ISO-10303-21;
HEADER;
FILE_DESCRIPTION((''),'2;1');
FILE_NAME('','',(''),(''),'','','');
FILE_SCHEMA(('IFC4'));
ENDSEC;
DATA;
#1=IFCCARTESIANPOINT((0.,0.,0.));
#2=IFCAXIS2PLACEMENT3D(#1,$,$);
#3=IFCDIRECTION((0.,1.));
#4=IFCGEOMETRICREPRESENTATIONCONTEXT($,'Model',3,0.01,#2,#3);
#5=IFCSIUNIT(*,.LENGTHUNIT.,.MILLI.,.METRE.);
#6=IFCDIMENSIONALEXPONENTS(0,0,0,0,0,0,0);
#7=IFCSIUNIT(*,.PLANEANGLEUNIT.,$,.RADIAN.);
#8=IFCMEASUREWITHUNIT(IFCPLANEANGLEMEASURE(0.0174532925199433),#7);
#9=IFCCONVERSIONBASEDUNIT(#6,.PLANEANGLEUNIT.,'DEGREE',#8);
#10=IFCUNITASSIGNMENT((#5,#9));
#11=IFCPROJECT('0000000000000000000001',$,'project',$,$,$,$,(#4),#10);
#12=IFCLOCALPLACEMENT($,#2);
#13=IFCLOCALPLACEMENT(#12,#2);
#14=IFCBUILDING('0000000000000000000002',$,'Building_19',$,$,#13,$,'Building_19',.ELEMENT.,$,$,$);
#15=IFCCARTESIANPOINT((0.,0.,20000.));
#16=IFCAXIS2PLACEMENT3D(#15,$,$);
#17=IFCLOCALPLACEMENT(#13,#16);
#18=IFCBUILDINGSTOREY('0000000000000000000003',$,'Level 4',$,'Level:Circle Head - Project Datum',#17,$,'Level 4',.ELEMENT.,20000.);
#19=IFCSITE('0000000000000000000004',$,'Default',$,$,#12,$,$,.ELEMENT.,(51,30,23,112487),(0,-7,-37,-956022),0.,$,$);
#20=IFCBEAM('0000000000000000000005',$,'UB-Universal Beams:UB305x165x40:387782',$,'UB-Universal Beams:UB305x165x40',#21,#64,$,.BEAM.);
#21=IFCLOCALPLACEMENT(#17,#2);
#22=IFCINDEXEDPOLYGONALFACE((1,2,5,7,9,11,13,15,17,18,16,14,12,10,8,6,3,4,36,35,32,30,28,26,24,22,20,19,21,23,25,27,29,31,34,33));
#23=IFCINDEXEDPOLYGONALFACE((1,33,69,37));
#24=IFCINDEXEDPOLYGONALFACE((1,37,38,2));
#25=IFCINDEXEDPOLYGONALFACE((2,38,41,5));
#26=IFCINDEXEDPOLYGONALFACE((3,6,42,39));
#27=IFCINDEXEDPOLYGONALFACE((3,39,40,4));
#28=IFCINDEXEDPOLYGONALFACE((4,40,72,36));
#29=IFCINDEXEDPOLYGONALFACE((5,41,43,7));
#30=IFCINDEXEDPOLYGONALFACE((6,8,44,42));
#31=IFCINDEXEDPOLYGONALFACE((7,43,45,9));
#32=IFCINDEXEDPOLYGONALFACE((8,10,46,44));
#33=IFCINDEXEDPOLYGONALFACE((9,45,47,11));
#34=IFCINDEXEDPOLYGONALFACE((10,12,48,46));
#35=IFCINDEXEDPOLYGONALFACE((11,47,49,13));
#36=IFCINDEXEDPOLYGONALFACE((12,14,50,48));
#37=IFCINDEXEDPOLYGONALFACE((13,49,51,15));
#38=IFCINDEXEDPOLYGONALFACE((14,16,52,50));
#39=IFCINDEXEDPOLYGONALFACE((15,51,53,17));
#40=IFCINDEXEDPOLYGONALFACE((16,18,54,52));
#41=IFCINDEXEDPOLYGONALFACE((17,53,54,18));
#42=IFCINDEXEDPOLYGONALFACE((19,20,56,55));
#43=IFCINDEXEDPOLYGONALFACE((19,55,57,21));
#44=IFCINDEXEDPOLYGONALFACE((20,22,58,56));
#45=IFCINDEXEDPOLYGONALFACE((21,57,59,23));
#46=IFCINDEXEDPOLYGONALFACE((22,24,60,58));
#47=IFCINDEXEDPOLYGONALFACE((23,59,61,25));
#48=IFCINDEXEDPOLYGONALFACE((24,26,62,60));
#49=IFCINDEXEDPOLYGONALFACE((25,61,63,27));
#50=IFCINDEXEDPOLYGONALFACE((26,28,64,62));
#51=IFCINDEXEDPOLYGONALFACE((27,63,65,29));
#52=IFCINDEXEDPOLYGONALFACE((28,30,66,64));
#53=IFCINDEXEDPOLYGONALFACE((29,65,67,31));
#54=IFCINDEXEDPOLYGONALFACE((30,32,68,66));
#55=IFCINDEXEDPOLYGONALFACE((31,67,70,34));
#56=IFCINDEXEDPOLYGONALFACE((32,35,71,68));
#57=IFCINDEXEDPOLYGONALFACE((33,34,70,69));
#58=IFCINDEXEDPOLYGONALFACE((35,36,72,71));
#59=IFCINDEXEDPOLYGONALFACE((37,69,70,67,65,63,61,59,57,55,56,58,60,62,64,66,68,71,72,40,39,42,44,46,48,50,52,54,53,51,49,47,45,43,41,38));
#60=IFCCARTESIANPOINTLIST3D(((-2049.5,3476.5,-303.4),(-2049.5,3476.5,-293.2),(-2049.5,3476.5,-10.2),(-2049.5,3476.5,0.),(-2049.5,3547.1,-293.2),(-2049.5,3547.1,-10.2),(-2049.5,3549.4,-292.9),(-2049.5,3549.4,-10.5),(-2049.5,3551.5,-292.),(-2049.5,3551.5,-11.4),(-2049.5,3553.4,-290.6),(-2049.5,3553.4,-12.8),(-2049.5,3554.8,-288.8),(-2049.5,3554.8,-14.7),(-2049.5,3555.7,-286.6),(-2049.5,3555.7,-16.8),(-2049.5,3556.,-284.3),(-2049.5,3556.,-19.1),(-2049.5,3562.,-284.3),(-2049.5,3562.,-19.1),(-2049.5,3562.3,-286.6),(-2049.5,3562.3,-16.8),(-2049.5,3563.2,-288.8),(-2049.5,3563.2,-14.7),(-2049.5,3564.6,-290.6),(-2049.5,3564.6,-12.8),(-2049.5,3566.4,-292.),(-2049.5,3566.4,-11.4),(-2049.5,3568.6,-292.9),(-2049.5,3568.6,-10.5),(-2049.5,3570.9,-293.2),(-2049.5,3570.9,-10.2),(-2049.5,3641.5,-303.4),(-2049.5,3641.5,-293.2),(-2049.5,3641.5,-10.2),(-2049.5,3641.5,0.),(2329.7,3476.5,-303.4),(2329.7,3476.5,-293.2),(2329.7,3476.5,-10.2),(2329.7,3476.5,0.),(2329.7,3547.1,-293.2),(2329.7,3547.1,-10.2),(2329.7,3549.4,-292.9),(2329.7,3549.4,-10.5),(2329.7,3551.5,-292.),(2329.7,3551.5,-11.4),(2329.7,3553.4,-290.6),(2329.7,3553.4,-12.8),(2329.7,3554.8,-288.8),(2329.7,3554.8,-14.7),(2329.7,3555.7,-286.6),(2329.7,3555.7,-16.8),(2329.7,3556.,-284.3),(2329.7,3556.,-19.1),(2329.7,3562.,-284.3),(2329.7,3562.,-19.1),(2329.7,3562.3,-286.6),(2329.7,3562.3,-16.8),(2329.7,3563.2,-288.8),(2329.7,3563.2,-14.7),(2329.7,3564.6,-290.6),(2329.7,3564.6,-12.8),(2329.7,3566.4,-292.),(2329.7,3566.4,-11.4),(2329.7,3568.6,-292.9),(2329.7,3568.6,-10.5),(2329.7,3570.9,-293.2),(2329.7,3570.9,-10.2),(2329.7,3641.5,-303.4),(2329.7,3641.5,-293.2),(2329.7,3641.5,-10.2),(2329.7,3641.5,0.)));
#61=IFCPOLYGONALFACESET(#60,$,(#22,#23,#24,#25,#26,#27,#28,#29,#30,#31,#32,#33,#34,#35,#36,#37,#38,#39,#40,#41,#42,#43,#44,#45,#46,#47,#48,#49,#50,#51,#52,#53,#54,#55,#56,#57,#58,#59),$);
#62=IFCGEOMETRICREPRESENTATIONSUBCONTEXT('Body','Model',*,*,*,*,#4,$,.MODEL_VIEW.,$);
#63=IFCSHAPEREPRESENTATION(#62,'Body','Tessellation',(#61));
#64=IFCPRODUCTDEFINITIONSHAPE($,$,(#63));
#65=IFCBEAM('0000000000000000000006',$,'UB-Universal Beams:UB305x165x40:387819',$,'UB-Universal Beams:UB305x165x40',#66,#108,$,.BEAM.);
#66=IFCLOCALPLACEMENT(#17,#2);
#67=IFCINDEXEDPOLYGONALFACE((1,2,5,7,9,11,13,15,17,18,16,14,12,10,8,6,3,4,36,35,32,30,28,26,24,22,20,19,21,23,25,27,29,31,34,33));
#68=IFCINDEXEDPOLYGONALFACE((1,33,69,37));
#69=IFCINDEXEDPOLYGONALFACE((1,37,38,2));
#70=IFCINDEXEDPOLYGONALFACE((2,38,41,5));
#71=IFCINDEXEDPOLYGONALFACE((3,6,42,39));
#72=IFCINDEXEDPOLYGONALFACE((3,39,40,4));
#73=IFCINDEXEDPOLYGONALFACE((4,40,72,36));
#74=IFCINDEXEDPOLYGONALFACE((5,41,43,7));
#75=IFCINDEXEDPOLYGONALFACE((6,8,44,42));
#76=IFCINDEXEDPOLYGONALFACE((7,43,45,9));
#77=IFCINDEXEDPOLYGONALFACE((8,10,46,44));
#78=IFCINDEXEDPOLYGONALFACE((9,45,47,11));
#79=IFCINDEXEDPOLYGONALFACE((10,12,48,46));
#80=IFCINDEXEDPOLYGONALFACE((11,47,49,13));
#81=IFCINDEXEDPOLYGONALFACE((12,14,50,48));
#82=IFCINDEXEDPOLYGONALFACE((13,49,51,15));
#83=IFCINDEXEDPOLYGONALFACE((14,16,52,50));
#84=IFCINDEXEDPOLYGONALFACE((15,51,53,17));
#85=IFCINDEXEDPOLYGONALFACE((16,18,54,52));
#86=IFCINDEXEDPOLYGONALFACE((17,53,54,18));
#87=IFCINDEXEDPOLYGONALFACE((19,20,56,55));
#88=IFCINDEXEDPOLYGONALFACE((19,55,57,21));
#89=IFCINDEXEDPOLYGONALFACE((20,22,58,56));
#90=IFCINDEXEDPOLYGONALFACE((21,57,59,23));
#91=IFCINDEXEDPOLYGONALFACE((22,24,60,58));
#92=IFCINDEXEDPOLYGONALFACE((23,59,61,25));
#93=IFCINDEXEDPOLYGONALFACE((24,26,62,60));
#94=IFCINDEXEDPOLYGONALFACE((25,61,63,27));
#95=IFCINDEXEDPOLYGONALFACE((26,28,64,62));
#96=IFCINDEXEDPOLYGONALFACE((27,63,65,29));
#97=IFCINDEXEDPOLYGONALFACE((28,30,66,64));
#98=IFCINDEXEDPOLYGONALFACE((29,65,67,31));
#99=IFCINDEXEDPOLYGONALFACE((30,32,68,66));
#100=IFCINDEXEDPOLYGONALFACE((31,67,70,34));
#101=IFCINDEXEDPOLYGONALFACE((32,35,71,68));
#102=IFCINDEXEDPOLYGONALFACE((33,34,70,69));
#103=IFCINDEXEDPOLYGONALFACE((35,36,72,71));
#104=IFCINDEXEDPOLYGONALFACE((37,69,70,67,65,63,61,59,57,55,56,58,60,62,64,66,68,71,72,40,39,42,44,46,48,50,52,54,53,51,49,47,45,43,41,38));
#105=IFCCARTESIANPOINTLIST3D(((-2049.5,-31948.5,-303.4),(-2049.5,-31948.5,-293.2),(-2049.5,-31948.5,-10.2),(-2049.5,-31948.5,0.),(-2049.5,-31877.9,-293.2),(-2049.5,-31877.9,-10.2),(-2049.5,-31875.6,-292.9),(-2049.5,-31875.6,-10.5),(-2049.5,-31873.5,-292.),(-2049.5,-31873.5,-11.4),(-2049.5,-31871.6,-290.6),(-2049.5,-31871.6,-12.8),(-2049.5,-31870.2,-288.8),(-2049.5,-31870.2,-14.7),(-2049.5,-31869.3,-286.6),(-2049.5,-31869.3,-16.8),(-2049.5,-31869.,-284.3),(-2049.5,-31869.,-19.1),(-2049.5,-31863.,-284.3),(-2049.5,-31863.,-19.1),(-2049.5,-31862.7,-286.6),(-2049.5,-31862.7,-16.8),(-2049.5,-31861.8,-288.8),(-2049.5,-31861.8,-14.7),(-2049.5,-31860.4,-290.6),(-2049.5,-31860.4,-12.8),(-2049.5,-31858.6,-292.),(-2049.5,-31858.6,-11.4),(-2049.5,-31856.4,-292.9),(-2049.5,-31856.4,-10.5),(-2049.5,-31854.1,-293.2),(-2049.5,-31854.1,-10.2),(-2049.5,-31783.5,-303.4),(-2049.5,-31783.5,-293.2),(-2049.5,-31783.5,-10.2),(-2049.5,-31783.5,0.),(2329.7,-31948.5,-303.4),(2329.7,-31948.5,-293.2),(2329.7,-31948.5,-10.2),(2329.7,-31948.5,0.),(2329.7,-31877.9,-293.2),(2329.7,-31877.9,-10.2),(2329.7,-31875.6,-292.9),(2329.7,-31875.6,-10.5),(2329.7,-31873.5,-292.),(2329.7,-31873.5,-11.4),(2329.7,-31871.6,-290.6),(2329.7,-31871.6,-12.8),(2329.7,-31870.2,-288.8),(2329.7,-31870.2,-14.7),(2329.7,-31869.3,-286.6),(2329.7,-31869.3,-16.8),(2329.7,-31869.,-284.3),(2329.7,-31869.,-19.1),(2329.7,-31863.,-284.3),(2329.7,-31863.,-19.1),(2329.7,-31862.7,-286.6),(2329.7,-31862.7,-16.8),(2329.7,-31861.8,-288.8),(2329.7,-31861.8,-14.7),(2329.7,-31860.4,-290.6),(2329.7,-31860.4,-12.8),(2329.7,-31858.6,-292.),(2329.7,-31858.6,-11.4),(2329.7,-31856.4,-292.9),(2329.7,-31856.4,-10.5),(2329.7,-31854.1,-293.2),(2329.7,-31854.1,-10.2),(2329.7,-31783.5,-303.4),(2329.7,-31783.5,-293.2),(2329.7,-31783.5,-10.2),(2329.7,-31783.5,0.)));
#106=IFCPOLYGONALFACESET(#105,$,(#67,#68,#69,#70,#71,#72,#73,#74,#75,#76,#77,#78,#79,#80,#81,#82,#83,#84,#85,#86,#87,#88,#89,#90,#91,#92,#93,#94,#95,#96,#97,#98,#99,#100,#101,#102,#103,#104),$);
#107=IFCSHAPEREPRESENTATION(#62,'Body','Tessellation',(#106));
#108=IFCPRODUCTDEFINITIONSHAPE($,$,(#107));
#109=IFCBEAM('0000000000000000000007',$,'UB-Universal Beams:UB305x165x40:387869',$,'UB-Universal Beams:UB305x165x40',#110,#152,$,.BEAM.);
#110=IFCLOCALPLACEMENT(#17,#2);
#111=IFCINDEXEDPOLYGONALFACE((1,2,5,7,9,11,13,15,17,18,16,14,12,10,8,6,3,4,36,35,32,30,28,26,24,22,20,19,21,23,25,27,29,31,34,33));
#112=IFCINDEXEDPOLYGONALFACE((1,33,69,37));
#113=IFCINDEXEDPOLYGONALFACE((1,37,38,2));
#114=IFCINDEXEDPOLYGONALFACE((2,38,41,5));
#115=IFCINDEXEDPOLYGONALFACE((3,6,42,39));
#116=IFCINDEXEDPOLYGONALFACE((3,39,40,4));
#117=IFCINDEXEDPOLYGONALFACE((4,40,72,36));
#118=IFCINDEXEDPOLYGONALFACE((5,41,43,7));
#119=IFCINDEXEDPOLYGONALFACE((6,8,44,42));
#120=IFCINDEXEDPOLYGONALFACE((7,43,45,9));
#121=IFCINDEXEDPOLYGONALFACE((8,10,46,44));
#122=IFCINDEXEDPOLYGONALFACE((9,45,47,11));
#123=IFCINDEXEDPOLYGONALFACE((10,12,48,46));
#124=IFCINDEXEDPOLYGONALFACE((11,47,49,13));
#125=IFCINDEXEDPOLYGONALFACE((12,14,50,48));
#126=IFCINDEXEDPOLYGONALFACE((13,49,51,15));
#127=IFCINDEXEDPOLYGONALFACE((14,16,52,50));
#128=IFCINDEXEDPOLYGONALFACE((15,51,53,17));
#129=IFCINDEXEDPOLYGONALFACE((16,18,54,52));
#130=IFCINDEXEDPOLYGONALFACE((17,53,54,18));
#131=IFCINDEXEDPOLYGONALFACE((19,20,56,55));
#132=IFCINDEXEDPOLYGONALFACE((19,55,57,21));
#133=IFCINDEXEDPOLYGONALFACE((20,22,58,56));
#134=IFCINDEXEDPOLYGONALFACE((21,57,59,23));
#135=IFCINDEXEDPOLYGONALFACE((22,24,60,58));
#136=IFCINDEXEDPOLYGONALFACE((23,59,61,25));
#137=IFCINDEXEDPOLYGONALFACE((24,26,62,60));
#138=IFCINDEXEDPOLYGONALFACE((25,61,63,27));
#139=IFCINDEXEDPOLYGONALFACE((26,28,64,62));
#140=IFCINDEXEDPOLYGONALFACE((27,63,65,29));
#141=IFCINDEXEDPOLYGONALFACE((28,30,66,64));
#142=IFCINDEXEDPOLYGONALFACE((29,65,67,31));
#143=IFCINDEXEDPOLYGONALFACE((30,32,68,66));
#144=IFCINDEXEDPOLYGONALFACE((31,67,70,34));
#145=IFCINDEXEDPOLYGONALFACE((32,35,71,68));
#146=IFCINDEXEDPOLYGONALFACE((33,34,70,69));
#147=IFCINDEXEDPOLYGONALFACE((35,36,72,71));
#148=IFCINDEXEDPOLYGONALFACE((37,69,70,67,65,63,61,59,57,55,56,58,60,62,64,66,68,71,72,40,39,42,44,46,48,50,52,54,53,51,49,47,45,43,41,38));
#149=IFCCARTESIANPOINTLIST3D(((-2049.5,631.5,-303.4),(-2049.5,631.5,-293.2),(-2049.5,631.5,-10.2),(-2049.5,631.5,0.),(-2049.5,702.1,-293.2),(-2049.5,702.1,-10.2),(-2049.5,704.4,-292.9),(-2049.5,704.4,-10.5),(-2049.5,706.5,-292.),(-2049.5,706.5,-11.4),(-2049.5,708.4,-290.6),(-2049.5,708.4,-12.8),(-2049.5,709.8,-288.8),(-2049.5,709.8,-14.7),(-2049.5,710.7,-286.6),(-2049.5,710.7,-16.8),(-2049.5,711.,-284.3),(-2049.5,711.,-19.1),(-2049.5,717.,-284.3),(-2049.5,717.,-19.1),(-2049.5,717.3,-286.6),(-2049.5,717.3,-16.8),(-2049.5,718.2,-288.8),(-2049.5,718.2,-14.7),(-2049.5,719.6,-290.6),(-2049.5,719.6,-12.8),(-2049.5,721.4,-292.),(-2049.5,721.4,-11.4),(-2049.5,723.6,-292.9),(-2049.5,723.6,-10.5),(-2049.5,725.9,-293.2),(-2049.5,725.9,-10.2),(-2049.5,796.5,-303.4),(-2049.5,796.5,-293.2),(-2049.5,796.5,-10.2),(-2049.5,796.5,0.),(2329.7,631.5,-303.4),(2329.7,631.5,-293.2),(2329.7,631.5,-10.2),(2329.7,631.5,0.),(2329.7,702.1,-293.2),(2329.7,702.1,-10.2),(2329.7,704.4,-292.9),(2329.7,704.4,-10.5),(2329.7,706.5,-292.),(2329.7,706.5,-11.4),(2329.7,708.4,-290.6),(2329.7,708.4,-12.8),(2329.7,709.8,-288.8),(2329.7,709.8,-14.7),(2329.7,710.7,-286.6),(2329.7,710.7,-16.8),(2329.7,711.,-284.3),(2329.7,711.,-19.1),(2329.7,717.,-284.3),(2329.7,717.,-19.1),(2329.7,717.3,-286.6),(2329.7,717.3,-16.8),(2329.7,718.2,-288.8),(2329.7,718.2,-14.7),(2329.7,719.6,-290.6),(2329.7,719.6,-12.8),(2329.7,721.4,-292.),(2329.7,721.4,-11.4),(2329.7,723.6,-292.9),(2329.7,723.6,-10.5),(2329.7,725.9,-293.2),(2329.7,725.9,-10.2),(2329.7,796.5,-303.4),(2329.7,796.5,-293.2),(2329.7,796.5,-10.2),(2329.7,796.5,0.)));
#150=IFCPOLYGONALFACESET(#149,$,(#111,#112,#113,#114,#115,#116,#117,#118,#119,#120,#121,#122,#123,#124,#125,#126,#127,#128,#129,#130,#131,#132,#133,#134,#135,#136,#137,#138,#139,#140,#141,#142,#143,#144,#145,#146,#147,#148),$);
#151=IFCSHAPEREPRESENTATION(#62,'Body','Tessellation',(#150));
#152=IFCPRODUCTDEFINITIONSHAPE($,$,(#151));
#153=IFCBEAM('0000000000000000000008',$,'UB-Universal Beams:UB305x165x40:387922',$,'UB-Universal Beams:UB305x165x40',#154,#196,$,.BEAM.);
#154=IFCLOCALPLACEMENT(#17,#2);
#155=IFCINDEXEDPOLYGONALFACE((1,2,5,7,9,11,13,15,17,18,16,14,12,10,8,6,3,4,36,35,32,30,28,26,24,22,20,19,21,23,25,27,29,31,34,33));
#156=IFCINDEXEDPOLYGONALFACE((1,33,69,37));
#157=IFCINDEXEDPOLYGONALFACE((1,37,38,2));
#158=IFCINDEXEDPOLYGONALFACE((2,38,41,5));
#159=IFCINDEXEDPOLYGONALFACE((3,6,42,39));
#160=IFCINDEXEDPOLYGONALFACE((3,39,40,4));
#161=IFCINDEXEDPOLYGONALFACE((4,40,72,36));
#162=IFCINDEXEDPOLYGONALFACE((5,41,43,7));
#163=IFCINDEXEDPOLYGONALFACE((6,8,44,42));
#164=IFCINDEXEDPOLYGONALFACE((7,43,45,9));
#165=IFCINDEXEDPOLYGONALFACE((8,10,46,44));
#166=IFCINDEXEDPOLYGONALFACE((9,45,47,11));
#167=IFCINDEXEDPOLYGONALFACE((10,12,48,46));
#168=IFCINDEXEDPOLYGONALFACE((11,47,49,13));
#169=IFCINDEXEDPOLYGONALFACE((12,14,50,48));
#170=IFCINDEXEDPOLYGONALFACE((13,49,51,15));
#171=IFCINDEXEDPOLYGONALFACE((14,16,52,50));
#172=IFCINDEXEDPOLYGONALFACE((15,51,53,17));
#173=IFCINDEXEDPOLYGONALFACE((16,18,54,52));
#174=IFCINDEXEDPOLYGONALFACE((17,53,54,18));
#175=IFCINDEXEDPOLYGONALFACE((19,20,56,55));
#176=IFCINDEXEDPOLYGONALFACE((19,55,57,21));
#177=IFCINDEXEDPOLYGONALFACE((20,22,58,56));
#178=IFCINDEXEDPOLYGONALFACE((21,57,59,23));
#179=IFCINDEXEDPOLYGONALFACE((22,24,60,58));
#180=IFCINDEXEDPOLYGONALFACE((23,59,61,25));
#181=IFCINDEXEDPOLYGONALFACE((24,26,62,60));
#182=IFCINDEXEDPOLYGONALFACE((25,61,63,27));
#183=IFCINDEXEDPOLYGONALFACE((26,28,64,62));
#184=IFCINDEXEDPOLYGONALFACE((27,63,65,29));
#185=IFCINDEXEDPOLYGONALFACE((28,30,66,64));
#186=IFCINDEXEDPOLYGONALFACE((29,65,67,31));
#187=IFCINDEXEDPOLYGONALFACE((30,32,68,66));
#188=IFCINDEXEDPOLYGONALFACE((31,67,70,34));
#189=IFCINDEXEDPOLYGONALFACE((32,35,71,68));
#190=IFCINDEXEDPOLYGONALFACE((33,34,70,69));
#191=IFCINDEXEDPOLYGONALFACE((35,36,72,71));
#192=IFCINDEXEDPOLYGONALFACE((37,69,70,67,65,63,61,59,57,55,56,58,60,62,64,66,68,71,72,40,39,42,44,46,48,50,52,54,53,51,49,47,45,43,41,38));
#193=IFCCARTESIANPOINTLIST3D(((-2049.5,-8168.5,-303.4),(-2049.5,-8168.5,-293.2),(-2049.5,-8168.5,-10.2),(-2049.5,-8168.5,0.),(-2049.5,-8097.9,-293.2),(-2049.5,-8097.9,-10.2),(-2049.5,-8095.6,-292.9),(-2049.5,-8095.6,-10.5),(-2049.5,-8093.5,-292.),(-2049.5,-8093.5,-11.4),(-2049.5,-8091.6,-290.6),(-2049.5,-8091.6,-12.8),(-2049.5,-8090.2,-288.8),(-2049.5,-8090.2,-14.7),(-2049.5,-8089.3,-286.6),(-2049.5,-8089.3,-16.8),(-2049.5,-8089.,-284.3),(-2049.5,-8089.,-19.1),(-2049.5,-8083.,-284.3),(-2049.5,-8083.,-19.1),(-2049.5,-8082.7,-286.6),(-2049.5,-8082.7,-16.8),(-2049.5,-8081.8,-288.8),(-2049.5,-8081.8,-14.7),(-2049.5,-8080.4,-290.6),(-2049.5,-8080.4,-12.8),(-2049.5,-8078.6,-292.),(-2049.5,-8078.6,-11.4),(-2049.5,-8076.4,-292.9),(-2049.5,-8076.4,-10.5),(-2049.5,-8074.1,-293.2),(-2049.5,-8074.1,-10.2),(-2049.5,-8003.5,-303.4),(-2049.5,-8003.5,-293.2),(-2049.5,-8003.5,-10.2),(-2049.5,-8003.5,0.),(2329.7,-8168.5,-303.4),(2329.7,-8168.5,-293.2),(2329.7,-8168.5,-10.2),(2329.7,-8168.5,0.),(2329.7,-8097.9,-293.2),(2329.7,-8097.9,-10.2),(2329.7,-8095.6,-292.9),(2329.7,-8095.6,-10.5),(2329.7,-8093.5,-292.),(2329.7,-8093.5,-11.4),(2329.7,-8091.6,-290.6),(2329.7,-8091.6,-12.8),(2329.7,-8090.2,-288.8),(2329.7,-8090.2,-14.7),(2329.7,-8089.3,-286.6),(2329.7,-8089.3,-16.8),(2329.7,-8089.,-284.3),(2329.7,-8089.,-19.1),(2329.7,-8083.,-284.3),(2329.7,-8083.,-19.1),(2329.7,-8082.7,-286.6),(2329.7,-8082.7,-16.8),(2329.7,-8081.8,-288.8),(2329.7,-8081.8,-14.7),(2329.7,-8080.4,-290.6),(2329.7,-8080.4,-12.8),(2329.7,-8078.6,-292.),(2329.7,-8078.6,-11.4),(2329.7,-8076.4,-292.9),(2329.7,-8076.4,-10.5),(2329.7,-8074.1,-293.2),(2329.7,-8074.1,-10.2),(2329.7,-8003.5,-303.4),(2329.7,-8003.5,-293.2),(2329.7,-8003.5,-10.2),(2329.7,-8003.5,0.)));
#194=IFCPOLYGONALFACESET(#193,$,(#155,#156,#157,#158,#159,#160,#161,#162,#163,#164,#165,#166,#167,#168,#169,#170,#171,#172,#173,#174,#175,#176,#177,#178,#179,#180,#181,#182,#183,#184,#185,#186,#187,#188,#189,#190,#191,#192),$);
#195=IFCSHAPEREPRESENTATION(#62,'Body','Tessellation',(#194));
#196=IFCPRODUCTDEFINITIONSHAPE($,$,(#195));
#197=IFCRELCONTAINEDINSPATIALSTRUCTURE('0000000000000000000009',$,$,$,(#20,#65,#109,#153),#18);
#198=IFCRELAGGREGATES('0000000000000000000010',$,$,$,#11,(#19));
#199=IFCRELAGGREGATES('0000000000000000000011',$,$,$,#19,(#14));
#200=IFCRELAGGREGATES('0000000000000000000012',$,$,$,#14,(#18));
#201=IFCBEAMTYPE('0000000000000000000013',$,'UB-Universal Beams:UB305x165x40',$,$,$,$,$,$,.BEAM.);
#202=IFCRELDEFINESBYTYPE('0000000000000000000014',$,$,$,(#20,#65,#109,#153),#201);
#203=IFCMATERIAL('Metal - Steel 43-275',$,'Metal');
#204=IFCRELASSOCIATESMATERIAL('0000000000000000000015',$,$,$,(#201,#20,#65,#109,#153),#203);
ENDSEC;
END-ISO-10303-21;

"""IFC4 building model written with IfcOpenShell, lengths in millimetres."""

from ifc_helpers import new_model, entity, si_unit, converted_unit, direction, frame, origin, place, context, subcontext, project, spatial, line, arc, indexed_curve, outline, extrude, source, transform, mapped, material, type_object, type_shapes, element, save


model = new_model("IFC4")

# Units and contexts
model_context = context("Model", 3, precision=0.01, world=origin(), true_north=direction((0.0, 1.0)))
body_context = subcontext(model_context, "Body", "Model", "MODEL_VIEW")
ifc_project = project(units=[si_unit("LENGTHUNIT", "METRE", prefix="MILLI"), converted_unit("PLANEANGLEUNIT", "DEGREE", entity("IfcPlaneAngleMeasure", 0.0174532925199433), si_unit("PLANEANGLEUNIT", "RADIAN"), dimensions=[0, 0, 0, 0, 0, 0, 0])], contexts=[model_context])

# Site, building, storey
site_placement = place(None, origin())
site = spatial("IfcSite", under=ifc_project, at=site_placement, Name="Default", CompositionType="ELEMENT", RefLatitude=(51, 30, 23, 112487), RefLongitude=(0, -7, -37, -956022), RefElevation=0.0)
building_placement = place(site_placement, origin())
building = spatial("IfcBuilding", under=site, at=building_placement, Name="Building_19", LongName="Building_19", CompositionType="ELEMENT")
storey_placement = place(building_placement, frame((0.0, 0.0, 20000.0)))
storey = spatial("IfcBuildingStorey", under=building, at=storey_placement, Name="Level 4", ObjectType="Level:Circle Head - Project Datum", LongName="Level 4", CompositionType="ELEMENT", Elevation=20000.0)

# Beams
ifc_material_1 = material(Name="Metal - Steel 43-275", Category="Metal")
beam_type_1 = type_object("IfcBeamType", Name="UB-Universal Beams:UB305x165x40", PredefinedType="BEAM", material=ifc_material_1)
shared_shape_1 = source(origin(), body_context, "Body", "SweptSolid", [
    extrude(outline(indexed_curve([(-82.5, -141.5), (-82.5, -151.7), (82.5, -151.7), (82.5, -141.5), (11.9, -141.5), (5.6, -138.9), (3.0, -132.6), (3.0, 132.6), (5.6, 138.9), (11.9, 141.5), (82.5, 141.5), (82.5, 151.7), (-82.5, 151.7), (-82.5, 141.5), (-11.9, 141.5), (-5.6, 138.9), (-3.0, 132.6), (-3.0, -132.6), (-5.6, -138.9), (-11.9, -141.5)], segments=[line(1, 2, 3, 4, 5), arc(5, 6, 7), line(7, 8), arc(8, 9, 10), line(10, 11, 12, 13, 14, 15), arc(15, 16, 17), line(17, 18), arc(18, 19, 20), line(20, 1)], self_intersect=False)), frame((-2189.6, 0.0, 0.0), z_axis=(-1.0, 0.0, 0.0), x_axis=(0.0, -1.0, 0.0)), (0.0, 0.0, -1.0), 4379.2),
])
type_shapes(beam_type_1, [shared_shape_1])
beam_1_placement = place(storey_placement, frame((140.1, 3559.0, -151.7)))
element("IfcBeam", 1, at=beam_1_placement, inside=storey, type_object=beam_type_1, material=ifc_material_1, Name="UB-Universal Beams:UB305x165x40:387782", ObjectType="UB-Universal Beams:UB305x165x40", PredefinedType="BEAM", context=body_context, shape_type="MappedRepresentation", body=[
    mapped(shared_shape_1, transform((0.0, 0.0, 0.0), scale=1.0)),
])
beam_2_placement = place(storey_placement, frame((140.1, -31866.0, -151.7), z_axis=(0.0, 0.0, 1.0), x_axis=(-1.0, 0.0, 0.0)))
element("IfcBeam", 2, at=beam_2_placement, inside=storey, type_object=beam_type_1, material=ifc_material_1, Name="UB-Universal Beams:UB305x165x40:387819", ObjectType="UB-Universal Beams:UB305x165x40", PredefinedType="BEAM", context=body_context, shape_type="MappedRepresentation", body=[
    mapped(shared_shape_1, transform((0.0, 0.0, 0.0), scale=1.0)),
])
for number, where, name in (
    (3, (140.1, 714.0, -151.7), "UB-Universal Beams:UB305x165x40:387869"),
    (4, (140.1, -8086.0, -151.7), "UB-Universal Beams:UB305x165x40:387922"),
):
    element("IfcBeam", number, at=place(storey_placement, frame(where)), inside=storey, type_object=beam_type_1, material=ifc_material_1, Name=name, ObjectType="UB-Universal Beams:UB305x165x40", PredefinedType="BEAM", context=body_context, shape_type="MappedRepresentation", body=[
        mapped(shared_shape_1, transform((0.0, 0.0, 0.0), scale=1.0)),
    ])

save(model, "model.ifc")
